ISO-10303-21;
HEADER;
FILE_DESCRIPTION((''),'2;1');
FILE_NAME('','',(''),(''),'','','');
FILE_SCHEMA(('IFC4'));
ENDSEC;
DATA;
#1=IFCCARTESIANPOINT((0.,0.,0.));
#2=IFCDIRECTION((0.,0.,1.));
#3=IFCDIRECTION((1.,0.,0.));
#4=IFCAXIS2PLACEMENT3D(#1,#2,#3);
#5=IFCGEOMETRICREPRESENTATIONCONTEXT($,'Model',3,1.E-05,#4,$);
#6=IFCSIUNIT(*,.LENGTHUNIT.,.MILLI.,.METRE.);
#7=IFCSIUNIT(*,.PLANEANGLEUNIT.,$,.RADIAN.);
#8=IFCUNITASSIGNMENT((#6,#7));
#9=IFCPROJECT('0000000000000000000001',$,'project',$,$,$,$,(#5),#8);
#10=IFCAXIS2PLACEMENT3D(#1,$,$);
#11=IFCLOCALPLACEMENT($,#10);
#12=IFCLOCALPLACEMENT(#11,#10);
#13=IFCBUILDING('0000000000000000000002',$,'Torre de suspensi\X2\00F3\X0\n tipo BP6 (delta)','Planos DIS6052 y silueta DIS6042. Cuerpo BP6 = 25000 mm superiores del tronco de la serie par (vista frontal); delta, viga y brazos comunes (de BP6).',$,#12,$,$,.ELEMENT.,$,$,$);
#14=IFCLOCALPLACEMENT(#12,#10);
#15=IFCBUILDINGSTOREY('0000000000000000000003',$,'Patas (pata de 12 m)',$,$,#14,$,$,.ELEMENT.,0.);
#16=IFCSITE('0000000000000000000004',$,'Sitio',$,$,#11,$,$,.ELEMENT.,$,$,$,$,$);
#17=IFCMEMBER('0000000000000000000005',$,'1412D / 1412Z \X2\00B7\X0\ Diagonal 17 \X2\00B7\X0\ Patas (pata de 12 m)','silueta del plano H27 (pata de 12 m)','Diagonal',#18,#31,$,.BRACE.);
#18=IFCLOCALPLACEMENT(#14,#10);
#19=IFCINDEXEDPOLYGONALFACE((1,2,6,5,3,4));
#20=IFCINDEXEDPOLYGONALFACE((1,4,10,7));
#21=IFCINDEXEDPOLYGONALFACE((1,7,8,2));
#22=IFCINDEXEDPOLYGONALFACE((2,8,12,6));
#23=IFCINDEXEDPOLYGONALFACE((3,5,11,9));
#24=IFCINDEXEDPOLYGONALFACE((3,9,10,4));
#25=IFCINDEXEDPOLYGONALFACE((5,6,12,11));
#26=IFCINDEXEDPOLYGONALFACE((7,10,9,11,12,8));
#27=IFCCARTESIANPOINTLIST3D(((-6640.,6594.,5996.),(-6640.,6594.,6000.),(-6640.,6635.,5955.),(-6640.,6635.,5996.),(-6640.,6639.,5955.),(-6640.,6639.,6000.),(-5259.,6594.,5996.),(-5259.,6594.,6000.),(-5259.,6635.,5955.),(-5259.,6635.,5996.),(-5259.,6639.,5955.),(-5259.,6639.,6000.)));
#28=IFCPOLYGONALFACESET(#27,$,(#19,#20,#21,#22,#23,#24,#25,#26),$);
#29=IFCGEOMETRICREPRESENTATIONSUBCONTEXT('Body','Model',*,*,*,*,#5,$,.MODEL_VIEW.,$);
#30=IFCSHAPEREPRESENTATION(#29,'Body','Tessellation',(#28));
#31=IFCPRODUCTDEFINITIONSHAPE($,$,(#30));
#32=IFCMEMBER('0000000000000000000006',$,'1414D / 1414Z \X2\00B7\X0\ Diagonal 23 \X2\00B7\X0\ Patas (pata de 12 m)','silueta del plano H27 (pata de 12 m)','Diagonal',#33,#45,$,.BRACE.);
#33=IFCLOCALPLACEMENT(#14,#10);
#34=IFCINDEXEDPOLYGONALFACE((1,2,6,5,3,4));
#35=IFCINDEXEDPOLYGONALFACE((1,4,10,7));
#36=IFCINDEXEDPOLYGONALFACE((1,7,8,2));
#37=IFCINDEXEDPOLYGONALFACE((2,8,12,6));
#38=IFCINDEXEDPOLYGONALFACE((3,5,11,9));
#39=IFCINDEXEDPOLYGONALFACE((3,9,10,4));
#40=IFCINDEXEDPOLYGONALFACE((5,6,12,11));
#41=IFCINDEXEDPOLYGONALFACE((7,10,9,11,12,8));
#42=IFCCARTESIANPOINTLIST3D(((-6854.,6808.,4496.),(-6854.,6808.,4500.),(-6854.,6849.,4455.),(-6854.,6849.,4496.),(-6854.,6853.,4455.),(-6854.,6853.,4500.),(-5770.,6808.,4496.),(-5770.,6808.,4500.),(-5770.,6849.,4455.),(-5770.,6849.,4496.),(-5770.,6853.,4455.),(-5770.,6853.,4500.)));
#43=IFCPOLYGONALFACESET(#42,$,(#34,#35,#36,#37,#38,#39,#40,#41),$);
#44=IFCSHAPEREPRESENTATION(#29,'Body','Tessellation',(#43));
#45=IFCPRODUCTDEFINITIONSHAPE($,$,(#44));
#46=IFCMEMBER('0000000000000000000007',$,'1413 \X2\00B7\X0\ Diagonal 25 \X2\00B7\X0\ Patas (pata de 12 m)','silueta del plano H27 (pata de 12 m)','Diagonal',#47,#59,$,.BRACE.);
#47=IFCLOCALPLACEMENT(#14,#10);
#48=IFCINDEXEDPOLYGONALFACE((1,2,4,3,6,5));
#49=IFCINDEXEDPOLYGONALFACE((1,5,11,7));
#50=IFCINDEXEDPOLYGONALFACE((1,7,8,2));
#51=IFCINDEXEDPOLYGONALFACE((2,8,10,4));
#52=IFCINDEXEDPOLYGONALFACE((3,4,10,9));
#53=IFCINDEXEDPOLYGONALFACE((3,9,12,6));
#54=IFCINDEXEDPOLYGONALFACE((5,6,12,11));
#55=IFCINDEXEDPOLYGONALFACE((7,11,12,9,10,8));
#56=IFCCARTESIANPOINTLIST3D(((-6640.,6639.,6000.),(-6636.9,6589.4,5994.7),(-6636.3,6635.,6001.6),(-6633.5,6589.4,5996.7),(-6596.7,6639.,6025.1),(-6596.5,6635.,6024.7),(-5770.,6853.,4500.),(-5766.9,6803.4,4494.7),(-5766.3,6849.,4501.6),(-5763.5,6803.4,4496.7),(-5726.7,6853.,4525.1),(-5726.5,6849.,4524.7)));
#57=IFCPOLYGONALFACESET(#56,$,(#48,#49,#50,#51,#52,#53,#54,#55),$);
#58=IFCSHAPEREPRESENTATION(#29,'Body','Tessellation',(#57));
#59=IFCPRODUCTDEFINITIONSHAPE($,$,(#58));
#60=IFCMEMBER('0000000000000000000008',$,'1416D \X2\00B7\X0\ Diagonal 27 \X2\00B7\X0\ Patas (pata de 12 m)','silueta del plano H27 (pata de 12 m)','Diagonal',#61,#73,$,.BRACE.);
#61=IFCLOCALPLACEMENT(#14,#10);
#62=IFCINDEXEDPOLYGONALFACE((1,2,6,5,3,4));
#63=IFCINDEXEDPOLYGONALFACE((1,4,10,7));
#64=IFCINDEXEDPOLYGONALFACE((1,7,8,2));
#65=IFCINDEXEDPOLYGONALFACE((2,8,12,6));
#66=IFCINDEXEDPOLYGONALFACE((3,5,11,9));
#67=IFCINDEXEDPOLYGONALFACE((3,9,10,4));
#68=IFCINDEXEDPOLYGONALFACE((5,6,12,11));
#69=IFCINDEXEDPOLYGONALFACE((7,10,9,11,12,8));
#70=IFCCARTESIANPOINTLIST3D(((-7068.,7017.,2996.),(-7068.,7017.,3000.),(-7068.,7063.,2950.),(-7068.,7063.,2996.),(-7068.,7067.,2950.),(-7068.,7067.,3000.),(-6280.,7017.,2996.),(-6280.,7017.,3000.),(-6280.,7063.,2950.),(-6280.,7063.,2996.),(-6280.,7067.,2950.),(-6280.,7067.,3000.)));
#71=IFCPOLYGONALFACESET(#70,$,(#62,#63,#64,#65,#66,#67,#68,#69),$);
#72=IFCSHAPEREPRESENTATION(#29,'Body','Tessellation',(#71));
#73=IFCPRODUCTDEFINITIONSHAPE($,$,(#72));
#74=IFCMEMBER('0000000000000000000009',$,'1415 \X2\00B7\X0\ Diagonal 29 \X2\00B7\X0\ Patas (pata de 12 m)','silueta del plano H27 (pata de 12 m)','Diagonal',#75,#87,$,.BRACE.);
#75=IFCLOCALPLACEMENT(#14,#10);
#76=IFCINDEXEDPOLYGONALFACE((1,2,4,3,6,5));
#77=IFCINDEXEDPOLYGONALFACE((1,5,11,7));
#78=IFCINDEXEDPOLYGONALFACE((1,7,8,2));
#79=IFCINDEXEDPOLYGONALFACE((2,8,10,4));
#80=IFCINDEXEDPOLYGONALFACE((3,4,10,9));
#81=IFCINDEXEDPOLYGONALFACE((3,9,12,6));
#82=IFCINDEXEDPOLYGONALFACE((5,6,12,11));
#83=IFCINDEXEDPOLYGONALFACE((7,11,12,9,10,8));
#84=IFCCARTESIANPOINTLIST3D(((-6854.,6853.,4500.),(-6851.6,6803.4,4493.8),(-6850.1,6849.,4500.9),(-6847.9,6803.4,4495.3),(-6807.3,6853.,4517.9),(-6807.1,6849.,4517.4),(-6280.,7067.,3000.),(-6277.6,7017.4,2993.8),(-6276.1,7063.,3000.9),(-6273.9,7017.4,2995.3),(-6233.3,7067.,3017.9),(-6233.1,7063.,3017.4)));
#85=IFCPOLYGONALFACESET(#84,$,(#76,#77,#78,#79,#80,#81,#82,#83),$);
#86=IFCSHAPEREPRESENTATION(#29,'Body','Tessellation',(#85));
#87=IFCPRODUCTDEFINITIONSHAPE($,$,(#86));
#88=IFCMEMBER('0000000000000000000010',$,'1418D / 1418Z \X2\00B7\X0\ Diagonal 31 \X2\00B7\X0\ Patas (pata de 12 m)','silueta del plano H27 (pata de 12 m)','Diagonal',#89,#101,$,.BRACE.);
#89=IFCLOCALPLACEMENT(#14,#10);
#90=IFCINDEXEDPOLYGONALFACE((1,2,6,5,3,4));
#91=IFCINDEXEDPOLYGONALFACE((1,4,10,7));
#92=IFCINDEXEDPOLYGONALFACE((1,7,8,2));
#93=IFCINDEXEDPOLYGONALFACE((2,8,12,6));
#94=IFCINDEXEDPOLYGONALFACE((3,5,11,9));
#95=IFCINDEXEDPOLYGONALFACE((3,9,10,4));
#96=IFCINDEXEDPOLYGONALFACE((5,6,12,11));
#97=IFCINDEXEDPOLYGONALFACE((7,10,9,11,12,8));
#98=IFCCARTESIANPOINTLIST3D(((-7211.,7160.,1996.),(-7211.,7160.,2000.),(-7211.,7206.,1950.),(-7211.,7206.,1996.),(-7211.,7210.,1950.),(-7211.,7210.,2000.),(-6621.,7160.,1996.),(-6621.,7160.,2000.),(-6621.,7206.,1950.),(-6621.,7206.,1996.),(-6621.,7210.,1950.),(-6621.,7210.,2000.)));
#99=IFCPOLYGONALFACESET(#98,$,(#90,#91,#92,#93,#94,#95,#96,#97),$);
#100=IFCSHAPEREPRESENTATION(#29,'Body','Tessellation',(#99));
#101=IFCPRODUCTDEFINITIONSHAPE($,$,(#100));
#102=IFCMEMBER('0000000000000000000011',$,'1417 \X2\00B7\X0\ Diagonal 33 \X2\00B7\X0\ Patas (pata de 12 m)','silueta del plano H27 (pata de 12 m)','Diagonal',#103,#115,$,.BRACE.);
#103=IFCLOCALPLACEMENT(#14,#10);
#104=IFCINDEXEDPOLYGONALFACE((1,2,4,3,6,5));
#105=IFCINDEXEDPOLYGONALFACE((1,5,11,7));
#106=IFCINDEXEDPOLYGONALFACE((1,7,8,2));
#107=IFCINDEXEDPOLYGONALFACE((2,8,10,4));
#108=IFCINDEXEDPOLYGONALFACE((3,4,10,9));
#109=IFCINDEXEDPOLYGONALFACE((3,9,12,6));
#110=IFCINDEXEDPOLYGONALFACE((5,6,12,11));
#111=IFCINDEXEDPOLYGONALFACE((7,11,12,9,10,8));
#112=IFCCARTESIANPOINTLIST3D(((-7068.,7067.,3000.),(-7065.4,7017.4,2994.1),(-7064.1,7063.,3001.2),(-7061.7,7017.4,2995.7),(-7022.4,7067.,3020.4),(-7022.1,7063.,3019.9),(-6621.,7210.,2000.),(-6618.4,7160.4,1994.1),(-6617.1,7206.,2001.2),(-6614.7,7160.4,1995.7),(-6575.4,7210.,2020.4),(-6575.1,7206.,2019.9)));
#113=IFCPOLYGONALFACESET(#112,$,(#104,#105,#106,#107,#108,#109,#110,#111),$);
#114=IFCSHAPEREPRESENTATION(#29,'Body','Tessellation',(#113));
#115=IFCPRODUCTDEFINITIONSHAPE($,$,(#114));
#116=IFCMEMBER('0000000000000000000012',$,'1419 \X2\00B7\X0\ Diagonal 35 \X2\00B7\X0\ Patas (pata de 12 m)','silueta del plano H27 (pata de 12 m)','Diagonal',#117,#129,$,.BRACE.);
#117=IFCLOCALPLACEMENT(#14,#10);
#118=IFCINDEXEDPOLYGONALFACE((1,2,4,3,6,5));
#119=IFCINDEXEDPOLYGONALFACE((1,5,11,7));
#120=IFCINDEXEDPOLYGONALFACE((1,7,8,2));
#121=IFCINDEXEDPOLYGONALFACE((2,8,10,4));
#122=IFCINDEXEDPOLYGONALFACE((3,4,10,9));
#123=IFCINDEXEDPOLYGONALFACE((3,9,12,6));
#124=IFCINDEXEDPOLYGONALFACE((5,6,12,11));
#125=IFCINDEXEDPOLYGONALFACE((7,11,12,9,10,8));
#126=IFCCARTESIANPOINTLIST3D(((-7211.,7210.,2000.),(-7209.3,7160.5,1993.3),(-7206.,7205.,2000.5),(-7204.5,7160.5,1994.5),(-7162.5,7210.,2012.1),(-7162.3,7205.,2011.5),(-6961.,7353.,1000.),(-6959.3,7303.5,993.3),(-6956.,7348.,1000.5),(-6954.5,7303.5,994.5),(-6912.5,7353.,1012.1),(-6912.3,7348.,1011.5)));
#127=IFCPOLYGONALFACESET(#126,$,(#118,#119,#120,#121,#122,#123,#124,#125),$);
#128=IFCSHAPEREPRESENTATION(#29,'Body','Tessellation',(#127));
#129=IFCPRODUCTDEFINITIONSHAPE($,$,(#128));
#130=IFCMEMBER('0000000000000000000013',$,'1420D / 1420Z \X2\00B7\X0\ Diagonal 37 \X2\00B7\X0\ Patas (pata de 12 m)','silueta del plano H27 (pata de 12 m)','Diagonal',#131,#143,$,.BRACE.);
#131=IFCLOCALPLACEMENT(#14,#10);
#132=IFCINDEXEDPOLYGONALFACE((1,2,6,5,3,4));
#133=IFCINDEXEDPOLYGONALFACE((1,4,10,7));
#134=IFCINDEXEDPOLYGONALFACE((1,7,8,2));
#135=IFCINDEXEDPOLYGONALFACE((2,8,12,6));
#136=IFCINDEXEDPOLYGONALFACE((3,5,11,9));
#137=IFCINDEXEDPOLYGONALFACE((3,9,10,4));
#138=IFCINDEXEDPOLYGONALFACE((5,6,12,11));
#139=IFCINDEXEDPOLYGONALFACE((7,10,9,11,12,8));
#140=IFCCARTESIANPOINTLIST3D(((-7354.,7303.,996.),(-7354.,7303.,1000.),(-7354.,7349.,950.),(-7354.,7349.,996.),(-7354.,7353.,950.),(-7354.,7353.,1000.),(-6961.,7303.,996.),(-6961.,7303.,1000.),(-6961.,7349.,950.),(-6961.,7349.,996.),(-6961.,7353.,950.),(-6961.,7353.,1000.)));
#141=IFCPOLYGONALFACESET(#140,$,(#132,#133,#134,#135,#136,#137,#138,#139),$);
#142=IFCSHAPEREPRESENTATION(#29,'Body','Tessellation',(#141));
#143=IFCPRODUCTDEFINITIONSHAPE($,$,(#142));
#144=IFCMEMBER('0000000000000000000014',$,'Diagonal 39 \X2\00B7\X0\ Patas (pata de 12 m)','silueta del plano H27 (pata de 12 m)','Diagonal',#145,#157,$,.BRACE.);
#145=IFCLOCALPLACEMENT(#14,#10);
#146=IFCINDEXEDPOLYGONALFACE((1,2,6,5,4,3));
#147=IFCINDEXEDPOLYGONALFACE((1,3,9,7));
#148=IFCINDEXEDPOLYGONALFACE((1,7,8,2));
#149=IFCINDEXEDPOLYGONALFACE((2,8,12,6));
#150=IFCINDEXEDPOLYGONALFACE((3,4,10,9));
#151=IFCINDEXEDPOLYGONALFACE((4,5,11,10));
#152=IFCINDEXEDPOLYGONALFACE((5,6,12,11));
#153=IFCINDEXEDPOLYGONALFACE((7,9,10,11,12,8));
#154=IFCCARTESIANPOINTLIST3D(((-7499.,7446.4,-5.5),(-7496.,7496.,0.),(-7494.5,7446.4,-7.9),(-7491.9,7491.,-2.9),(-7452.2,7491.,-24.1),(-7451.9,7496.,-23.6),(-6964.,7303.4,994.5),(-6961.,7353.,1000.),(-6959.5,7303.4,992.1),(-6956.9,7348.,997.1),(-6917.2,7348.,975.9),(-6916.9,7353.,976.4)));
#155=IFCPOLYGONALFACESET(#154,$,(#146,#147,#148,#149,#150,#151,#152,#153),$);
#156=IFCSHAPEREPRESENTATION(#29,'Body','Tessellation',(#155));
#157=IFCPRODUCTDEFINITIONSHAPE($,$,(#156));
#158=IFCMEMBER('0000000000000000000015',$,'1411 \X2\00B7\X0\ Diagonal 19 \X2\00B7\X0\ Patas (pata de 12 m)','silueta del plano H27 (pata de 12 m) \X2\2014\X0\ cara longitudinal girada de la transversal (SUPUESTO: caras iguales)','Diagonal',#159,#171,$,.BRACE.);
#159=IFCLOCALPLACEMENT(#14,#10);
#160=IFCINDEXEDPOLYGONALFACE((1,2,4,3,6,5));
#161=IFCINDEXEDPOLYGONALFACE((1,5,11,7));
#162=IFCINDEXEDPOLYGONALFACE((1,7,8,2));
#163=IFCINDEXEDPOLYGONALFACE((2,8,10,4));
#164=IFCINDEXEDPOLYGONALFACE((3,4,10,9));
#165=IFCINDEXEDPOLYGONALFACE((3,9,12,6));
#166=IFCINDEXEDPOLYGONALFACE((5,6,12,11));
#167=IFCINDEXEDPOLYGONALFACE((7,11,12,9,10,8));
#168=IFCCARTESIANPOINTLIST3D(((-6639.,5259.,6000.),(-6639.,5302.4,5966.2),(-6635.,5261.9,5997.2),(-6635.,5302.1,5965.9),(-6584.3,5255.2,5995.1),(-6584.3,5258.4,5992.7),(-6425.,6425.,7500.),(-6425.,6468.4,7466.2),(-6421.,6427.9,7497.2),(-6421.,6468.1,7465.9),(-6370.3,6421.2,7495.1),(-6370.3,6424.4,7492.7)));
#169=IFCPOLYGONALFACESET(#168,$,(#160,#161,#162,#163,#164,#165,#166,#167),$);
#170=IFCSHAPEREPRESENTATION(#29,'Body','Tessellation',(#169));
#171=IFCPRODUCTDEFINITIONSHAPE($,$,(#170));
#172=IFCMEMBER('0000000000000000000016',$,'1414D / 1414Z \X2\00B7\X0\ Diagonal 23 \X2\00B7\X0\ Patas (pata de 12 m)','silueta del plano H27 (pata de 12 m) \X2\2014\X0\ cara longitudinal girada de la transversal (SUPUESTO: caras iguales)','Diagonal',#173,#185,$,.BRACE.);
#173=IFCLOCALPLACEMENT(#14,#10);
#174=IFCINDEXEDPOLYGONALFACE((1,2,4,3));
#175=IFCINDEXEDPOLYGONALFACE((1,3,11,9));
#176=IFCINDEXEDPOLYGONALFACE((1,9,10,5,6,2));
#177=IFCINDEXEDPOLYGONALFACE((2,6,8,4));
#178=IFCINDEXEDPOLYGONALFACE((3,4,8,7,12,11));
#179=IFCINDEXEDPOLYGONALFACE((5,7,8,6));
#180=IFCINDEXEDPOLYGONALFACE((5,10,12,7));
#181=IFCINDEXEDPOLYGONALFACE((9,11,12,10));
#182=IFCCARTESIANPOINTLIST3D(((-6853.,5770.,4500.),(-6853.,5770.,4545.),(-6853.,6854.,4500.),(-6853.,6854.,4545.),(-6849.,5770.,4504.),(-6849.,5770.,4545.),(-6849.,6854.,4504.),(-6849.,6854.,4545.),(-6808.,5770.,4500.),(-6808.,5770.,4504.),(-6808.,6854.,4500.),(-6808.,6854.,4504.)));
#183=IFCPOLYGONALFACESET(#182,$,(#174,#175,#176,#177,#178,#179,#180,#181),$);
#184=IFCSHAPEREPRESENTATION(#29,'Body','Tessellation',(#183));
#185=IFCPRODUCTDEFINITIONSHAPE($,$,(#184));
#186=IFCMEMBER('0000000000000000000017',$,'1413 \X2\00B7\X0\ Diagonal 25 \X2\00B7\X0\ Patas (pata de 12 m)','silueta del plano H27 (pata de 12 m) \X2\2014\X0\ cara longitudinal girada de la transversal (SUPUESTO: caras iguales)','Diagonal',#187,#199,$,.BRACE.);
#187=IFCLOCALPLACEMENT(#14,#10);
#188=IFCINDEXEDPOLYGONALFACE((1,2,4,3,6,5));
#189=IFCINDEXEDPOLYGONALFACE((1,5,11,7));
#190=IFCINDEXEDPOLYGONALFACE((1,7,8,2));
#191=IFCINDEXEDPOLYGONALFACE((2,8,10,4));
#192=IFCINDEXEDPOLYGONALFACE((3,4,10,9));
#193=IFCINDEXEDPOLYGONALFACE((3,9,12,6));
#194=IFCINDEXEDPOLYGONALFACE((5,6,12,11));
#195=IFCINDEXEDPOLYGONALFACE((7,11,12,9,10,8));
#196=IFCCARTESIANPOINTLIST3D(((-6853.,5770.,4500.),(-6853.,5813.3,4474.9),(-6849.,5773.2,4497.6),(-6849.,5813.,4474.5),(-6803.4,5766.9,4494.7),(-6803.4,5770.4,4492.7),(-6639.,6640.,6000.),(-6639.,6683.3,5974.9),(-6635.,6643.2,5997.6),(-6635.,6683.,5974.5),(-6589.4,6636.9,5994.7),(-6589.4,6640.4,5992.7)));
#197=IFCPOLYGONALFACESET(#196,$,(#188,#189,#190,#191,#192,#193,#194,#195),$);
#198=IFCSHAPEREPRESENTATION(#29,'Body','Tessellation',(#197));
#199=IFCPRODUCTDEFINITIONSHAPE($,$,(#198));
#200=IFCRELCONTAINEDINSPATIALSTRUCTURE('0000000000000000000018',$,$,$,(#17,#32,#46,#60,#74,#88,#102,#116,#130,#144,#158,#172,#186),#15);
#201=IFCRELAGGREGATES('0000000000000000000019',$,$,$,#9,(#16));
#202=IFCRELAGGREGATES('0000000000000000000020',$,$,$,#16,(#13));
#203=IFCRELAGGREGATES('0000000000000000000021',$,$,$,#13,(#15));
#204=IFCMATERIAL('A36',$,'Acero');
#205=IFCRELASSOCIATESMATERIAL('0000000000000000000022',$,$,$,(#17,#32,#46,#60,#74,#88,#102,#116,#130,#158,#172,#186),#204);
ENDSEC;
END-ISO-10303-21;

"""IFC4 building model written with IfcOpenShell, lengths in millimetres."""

from ifc_helpers import new_model, si_unit, frame, frame_2d, origin, origin_with_axes, place, context, subcontext, project, spatial, l_section, extrude, material, element, save


model = new_model("IFC4")

# Units and contexts
model_context = context("Model", 3, precision=1e-05, world=origin_with_axes())
body_context = subcontext(model_context, "Body", "Model", "MODEL_VIEW")
ifc_project = project(units=[si_unit("LENGTHUNIT", "METRE", prefix="MILLI"), si_unit("PLANEANGLEUNIT", "RADIAN")], contexts=[model_context])

# Site, building, storey
site_placement = place(None, origin())
site = spatial("IfcSite", under=ifc_project, at=site_placement, Name="Sitio", CompositionType="ELEMENT")
building_placement = place(site_placement, origin())
building = spatial("IfcBuilding", under=site, at=building_placement, Name="Torre de suspensión tipo BP6 (delta)", Description="Planos DIS6052 y silueta DIS6042. Cuerpo BP6 = 25000 mm superiores del tronco de la serie par (vista frontal); delta, viga y brazos comunes (de BP6).", CompositionType="ELEMENT")
storey_placement = place(building_placement, origin())
storey = spatial("IfcBuildingStorey", under=building, at=storey_placement, Name="Patas (pata de 12 m)", CompositionType="ELEMENT", Elevation=0.0)

# Members
ifc_material = material(Name="A36", Category="Acero")
member_1_placement = place(storey_placement, frame((-6640.0, 6639.0, 6000.0), z_axis=(1.0, 0.0, 0.0), x_axis=(0.0, -1.0, 0.0)))
element("IfcMember", 1, at=member_1_placement, inside=storey, material=ifc_material, Name="1412D / 1412Z · Diagonal 17 · Patas (pata de 12 m)", Description="silueta del plano H27 (pata de 12 m)", ObjectType="Diagonal", PredefinedType="BRACE", context=body_context, shape_type="SweptSolid", body=[
    extrude(l_section(Depth=45.0, Width=45.0, Thickness=4.0, at=frame_2d((22.5, 22.5))), None, (0.0, 0.0, 1.0), 1381.0),
])
member_2_placement = place(storey_placement, frame((-6854.0, 6853.0, 4500.0), z_axis=(1.0, 0.0, 0.0), x_axis=(0.0, -1.0, 0.0)))
element("IfcMember", 2, at=member_2_placement, inside=storey, material=ifc_material, Name="1414D / 1414Z · Diagonal 23 · Patas (pata de 12 m)", Description="silueta del plano H27 (pata de 12 m)", ObjectType="Diagonal", PredefinedType="BRACE", context=body_context, shape_type="SweptSolid", body=[
    extrude(l_section(Depth=45.0, Width=45.0, Thickness=4.0, at=frame_2d((22.5, 22.5))), None, (0.0, 0.0, 1.0), 1084.0),
])
member_3_placement = place(storey_placement, frame((-5770.0, 6853.0, 4500.0), z_axis=(-0.497941, -0.122482, 0.858518), x_axis=(0.061451, -0.992471, -0.105951)))
element("IfcMember", 3, at=member_3_placement, inside=storey, material=ifc_material, Name="1413 · Diagonal 25 · Patas (pata de 12 m)", Description="silueta del plano H27 (pata de 12 m)", ObjectType="Diagonal", PredefinedType="BRACE", context=body_context, shape_type="SweptSolid", body=[
    extrude(l_section(Depth=50.0, Width=50.0, Thickness=4.0, at=frame_2d((25.0, 25.0))), None, (0.0, 0.0, 1.0), 1747.2),
])
member_4_placement = place(storey_placement, frame((-7068.0, 7067.0, 3000.0), z_axis=(1.0, 0.0, 0.0), x_axis=(0.0, -1.0, 0.0)))
element("IfcMember", 4, at=member_4_placement, inside=storey, material=ifc_material, Name="1416D · Diagonal 27 · Patas (pata de 12 m)", Description="silueta del plano H27 (pata de 12 m)", ObjectType="Diagonal", PredefinedType="BRACE", context=body_context, shape_type="SweptSolid", body=[
    extrude(l_section(Depth=50.0, Width=50.0, Thickness=4.0, at=frame_2d((25.0, 25.0))), None, (0.0, 0.0, 1.0), 788.0),
])
member_5_placement = place(storey_placement, frame((-6280.0, 7067.0, 3000.0), z_axis=(-0.354262, -0.132077, 0.925772), x_axis=(0.047203, -0.991239, -0.123354)))
element("IfcMember", 5, at=member_5_placement, inside=storey, material=ifc_material, Name="1415 · Diagonal 29 · Patas (pata de 12 m)", Description="silueta del plano H27 (pata de 12 m)", ObjectType="Diagonal", PredefinedType="BRACE", context=body_context, shape_type="SweptSolid", body=[
    extrude(l_section(Depth=50.0, Width=50.0, Thickness=4.0, at=frame_2d((25.0, 25.0))), None, (0.0, 0.0, 1.0), 1620.3),
])
member_6_placement = place(storey_placement, frame((-7211.0, 7210.0, 2000.0), z_axis=(1.0, 0.0, 0.0), x_axis=(0.0, -1.0, 0.0)))
element("IfcMember", 6, at=member_6_placement, inside=storey, material=ifc_material, Name="1418D / 1418Z · Diagonal 31 · Patas (pata de 12 m)", Description="silueta del plano H27 (pata de 12 m)", ObjectType="Diagonal", PredefinedType="BRACE", context=body_context, shape_type="SweptSolid", body=[
    extrude(l_section(Depth=50.0, Width=50.0, Thickness=4.0, at=frame_2d((25.0, 25.0))), None, (0.0, 0.0, 1.0), 590.0),
])
member_7_placement = place(storey_placement, frame((-6621.0, 7210.0, 2000.0), z_axis=(-0.404652, -0.129452, 0.905262), x_axis=(0.052828, -0.991586, -0.118183)))
element("IfcMember", 7, at=member_7_placement, inside=storey, material=ifc_material, Name="1417 · Diagonal 33 · Patas (pata de 12 m)", Description="silueta del plano H27 (pata de 12 m)", ObjectType="Diagonal", PredefinedType="BRACE", context=body_context, shape_type="SweptSolid", body=[
    extrude(l_section(Depth=50.0, Width=50.0, Thickness=4.0, at=frame_2d((25.0, 25.0))), None, (0.0, 0.0, 1.0), 1104.7),
])
member_8_placement = place(storey_placement, frame((-6961.0, 7353.0, 1000.0), z_axis=(-0.240235, -0.137414, 0.960939), x_axis=(0.033328, -0.990514, -0.133311)))
element("IfcMember", 8, at=member_8_placement, inside=storey, material=ifc_material, Name="1419 · Diagonal 35 · Patas (pata de 12 m)", Description="silueta del plano H27 (pata de 12 m)", ObjectType="Diagonal", PredefinedType="BRACE", context=body_context, shape_type="SweptSolid", body=[
    extrude(l_section(Depth=50.0, Width=50.0, Thickness=5.0, at=frame_2d((25.0, 25.0))), None, (0.0, 0.0, 1.0), 1040.6),
])
member_9_placement = place(storey_placement, frame((-7354.0, 7353.0, 1000.0), z_axis=(1.0, 0.0, 0.0), x_axis=(0.0, -1.0, 0.0)))
element("IfcMember", 9, at=member_9_placement, inside=storey, material=ifc_material, Name="1420D / 1420Z · Diagonal 37 · Patas (pata de 12 m)", Description="silueta del plano H27 (pata de 12 m)", ObjectType="Diagonal", PredefinedType="BRACE", context=body_context, shape_type="SweptSolid", body=[
    extrude(l_section(Depth=50.0, Width=50.0, Thickness=4.0, at=frame_2d((25.0, 25.0))), None, (0.0, 0.0, 1.0), 393.0),
])
member_10_placement = place(storey_placement, frame((-7496.0, 7496.0, 0.0), z_axis=(0.468026, -0.125099, 0.874815), x_axis=(-0.059013, -0.992144, -0.110305)))
element("IfcMember", 10, at=member_10_placement, inside=storey, Name="Diagonal 39 · Patas (pata de 12 m)", Description="silueta del plano H27 (pata de 12 m)", ObjectType="Diagonal", PredefinedType="BRACE", context=body_context, shape_type="SweptSolid", body=[
    extrude(l_section(Depth=50.0, Width=50.0, Thickness=5.0, at=frame_2d((25.0, 25.0))), None, (0.0, 0.0, 1.0), 1143.1),
])
member_11_placement = place(storey_placement, frame((-6639.0, 5259.0, 6000.0), z_axis=(0.111931, 0.609865, 0.784561), x_axis=(0.993716, -0.068694, -0.088372)))
element("IfcMember", 11, at=member_11_placement, inside=storey, material=ifc_material, Name="1411 · Diagonal 19 · Patas (pata de 12 m)", Description="silueta del plano H27 (pata de 12 m) — cara longitudinal girada de la transversal (SUPUESTO: caras iguales)", ObjectType="Diagonal", PredefinedType="BRACE", context=body_context, shape_type="SweptSolid", body=[
    extrude(l_section(Depth=55.0, Width=55.0, Thickness=4.0, at=frame_2d((27.5, 27.5))), None, (0.0, 0.0, 1.0), 1911.9),
])
member_12_placement = place(storey_placement, frame((-6853.0, 6854.0, 4500.0), z_axis=(0.0, -1.0, 0.0), x_axis=(1.0, 0.0, 0.0)))
element("IfcMember", 12, at=member_12_placement, inside=storey, material=ifc_material, Name="1414D / 1414Z · Diagonal 23 · Patas (pata de 12 m)", Description="silueta del plano H27 (pata de 12 m) — cara longitudinal girada de la transversal (SUPUESTO: caras iguales)", ObjectType="Diagonal", PredefinedType="BRACE", context=body_context, shape_type="SweptSolid", body=[
    extrude(l_section(Depth=45.0, Width=45.0, Thickness=4.0, at=frame_2d((22.5, 22.5))), None, (0.0, 0.0, 1.0), 1084.0),
])
member_13_placement = place(storey_placement, frame((-6853.0, 5770.0, 4500.0), z_axis=(0.122482, 0.497941, 0.858518), x_axis=(0.992471, -0.061451, -0.105951)))
element("IfcMember", 13, at=member_13_placement, inside=storey, material=ifc_material, Name="1413 · Diagonal 25 · Patas (pata de 12 m)", Description="silueta del plano H27 (pata de 12 m) — cara longitudinal girada de la transversal (SUPUESTO: caras iguales)", ObjectType="Diagonal", PredefinedType="BRACE", context=body_context, shape_type="SweptSolid", body=[
    extrude(l_section(Depth=50.0, Width=50.0, Thickness=4.0, at=frame_2d((25.0, 25.0))), None, (0.0, 0.0, 1.0), 1747.2),
])

save(model, "model.ifc")
